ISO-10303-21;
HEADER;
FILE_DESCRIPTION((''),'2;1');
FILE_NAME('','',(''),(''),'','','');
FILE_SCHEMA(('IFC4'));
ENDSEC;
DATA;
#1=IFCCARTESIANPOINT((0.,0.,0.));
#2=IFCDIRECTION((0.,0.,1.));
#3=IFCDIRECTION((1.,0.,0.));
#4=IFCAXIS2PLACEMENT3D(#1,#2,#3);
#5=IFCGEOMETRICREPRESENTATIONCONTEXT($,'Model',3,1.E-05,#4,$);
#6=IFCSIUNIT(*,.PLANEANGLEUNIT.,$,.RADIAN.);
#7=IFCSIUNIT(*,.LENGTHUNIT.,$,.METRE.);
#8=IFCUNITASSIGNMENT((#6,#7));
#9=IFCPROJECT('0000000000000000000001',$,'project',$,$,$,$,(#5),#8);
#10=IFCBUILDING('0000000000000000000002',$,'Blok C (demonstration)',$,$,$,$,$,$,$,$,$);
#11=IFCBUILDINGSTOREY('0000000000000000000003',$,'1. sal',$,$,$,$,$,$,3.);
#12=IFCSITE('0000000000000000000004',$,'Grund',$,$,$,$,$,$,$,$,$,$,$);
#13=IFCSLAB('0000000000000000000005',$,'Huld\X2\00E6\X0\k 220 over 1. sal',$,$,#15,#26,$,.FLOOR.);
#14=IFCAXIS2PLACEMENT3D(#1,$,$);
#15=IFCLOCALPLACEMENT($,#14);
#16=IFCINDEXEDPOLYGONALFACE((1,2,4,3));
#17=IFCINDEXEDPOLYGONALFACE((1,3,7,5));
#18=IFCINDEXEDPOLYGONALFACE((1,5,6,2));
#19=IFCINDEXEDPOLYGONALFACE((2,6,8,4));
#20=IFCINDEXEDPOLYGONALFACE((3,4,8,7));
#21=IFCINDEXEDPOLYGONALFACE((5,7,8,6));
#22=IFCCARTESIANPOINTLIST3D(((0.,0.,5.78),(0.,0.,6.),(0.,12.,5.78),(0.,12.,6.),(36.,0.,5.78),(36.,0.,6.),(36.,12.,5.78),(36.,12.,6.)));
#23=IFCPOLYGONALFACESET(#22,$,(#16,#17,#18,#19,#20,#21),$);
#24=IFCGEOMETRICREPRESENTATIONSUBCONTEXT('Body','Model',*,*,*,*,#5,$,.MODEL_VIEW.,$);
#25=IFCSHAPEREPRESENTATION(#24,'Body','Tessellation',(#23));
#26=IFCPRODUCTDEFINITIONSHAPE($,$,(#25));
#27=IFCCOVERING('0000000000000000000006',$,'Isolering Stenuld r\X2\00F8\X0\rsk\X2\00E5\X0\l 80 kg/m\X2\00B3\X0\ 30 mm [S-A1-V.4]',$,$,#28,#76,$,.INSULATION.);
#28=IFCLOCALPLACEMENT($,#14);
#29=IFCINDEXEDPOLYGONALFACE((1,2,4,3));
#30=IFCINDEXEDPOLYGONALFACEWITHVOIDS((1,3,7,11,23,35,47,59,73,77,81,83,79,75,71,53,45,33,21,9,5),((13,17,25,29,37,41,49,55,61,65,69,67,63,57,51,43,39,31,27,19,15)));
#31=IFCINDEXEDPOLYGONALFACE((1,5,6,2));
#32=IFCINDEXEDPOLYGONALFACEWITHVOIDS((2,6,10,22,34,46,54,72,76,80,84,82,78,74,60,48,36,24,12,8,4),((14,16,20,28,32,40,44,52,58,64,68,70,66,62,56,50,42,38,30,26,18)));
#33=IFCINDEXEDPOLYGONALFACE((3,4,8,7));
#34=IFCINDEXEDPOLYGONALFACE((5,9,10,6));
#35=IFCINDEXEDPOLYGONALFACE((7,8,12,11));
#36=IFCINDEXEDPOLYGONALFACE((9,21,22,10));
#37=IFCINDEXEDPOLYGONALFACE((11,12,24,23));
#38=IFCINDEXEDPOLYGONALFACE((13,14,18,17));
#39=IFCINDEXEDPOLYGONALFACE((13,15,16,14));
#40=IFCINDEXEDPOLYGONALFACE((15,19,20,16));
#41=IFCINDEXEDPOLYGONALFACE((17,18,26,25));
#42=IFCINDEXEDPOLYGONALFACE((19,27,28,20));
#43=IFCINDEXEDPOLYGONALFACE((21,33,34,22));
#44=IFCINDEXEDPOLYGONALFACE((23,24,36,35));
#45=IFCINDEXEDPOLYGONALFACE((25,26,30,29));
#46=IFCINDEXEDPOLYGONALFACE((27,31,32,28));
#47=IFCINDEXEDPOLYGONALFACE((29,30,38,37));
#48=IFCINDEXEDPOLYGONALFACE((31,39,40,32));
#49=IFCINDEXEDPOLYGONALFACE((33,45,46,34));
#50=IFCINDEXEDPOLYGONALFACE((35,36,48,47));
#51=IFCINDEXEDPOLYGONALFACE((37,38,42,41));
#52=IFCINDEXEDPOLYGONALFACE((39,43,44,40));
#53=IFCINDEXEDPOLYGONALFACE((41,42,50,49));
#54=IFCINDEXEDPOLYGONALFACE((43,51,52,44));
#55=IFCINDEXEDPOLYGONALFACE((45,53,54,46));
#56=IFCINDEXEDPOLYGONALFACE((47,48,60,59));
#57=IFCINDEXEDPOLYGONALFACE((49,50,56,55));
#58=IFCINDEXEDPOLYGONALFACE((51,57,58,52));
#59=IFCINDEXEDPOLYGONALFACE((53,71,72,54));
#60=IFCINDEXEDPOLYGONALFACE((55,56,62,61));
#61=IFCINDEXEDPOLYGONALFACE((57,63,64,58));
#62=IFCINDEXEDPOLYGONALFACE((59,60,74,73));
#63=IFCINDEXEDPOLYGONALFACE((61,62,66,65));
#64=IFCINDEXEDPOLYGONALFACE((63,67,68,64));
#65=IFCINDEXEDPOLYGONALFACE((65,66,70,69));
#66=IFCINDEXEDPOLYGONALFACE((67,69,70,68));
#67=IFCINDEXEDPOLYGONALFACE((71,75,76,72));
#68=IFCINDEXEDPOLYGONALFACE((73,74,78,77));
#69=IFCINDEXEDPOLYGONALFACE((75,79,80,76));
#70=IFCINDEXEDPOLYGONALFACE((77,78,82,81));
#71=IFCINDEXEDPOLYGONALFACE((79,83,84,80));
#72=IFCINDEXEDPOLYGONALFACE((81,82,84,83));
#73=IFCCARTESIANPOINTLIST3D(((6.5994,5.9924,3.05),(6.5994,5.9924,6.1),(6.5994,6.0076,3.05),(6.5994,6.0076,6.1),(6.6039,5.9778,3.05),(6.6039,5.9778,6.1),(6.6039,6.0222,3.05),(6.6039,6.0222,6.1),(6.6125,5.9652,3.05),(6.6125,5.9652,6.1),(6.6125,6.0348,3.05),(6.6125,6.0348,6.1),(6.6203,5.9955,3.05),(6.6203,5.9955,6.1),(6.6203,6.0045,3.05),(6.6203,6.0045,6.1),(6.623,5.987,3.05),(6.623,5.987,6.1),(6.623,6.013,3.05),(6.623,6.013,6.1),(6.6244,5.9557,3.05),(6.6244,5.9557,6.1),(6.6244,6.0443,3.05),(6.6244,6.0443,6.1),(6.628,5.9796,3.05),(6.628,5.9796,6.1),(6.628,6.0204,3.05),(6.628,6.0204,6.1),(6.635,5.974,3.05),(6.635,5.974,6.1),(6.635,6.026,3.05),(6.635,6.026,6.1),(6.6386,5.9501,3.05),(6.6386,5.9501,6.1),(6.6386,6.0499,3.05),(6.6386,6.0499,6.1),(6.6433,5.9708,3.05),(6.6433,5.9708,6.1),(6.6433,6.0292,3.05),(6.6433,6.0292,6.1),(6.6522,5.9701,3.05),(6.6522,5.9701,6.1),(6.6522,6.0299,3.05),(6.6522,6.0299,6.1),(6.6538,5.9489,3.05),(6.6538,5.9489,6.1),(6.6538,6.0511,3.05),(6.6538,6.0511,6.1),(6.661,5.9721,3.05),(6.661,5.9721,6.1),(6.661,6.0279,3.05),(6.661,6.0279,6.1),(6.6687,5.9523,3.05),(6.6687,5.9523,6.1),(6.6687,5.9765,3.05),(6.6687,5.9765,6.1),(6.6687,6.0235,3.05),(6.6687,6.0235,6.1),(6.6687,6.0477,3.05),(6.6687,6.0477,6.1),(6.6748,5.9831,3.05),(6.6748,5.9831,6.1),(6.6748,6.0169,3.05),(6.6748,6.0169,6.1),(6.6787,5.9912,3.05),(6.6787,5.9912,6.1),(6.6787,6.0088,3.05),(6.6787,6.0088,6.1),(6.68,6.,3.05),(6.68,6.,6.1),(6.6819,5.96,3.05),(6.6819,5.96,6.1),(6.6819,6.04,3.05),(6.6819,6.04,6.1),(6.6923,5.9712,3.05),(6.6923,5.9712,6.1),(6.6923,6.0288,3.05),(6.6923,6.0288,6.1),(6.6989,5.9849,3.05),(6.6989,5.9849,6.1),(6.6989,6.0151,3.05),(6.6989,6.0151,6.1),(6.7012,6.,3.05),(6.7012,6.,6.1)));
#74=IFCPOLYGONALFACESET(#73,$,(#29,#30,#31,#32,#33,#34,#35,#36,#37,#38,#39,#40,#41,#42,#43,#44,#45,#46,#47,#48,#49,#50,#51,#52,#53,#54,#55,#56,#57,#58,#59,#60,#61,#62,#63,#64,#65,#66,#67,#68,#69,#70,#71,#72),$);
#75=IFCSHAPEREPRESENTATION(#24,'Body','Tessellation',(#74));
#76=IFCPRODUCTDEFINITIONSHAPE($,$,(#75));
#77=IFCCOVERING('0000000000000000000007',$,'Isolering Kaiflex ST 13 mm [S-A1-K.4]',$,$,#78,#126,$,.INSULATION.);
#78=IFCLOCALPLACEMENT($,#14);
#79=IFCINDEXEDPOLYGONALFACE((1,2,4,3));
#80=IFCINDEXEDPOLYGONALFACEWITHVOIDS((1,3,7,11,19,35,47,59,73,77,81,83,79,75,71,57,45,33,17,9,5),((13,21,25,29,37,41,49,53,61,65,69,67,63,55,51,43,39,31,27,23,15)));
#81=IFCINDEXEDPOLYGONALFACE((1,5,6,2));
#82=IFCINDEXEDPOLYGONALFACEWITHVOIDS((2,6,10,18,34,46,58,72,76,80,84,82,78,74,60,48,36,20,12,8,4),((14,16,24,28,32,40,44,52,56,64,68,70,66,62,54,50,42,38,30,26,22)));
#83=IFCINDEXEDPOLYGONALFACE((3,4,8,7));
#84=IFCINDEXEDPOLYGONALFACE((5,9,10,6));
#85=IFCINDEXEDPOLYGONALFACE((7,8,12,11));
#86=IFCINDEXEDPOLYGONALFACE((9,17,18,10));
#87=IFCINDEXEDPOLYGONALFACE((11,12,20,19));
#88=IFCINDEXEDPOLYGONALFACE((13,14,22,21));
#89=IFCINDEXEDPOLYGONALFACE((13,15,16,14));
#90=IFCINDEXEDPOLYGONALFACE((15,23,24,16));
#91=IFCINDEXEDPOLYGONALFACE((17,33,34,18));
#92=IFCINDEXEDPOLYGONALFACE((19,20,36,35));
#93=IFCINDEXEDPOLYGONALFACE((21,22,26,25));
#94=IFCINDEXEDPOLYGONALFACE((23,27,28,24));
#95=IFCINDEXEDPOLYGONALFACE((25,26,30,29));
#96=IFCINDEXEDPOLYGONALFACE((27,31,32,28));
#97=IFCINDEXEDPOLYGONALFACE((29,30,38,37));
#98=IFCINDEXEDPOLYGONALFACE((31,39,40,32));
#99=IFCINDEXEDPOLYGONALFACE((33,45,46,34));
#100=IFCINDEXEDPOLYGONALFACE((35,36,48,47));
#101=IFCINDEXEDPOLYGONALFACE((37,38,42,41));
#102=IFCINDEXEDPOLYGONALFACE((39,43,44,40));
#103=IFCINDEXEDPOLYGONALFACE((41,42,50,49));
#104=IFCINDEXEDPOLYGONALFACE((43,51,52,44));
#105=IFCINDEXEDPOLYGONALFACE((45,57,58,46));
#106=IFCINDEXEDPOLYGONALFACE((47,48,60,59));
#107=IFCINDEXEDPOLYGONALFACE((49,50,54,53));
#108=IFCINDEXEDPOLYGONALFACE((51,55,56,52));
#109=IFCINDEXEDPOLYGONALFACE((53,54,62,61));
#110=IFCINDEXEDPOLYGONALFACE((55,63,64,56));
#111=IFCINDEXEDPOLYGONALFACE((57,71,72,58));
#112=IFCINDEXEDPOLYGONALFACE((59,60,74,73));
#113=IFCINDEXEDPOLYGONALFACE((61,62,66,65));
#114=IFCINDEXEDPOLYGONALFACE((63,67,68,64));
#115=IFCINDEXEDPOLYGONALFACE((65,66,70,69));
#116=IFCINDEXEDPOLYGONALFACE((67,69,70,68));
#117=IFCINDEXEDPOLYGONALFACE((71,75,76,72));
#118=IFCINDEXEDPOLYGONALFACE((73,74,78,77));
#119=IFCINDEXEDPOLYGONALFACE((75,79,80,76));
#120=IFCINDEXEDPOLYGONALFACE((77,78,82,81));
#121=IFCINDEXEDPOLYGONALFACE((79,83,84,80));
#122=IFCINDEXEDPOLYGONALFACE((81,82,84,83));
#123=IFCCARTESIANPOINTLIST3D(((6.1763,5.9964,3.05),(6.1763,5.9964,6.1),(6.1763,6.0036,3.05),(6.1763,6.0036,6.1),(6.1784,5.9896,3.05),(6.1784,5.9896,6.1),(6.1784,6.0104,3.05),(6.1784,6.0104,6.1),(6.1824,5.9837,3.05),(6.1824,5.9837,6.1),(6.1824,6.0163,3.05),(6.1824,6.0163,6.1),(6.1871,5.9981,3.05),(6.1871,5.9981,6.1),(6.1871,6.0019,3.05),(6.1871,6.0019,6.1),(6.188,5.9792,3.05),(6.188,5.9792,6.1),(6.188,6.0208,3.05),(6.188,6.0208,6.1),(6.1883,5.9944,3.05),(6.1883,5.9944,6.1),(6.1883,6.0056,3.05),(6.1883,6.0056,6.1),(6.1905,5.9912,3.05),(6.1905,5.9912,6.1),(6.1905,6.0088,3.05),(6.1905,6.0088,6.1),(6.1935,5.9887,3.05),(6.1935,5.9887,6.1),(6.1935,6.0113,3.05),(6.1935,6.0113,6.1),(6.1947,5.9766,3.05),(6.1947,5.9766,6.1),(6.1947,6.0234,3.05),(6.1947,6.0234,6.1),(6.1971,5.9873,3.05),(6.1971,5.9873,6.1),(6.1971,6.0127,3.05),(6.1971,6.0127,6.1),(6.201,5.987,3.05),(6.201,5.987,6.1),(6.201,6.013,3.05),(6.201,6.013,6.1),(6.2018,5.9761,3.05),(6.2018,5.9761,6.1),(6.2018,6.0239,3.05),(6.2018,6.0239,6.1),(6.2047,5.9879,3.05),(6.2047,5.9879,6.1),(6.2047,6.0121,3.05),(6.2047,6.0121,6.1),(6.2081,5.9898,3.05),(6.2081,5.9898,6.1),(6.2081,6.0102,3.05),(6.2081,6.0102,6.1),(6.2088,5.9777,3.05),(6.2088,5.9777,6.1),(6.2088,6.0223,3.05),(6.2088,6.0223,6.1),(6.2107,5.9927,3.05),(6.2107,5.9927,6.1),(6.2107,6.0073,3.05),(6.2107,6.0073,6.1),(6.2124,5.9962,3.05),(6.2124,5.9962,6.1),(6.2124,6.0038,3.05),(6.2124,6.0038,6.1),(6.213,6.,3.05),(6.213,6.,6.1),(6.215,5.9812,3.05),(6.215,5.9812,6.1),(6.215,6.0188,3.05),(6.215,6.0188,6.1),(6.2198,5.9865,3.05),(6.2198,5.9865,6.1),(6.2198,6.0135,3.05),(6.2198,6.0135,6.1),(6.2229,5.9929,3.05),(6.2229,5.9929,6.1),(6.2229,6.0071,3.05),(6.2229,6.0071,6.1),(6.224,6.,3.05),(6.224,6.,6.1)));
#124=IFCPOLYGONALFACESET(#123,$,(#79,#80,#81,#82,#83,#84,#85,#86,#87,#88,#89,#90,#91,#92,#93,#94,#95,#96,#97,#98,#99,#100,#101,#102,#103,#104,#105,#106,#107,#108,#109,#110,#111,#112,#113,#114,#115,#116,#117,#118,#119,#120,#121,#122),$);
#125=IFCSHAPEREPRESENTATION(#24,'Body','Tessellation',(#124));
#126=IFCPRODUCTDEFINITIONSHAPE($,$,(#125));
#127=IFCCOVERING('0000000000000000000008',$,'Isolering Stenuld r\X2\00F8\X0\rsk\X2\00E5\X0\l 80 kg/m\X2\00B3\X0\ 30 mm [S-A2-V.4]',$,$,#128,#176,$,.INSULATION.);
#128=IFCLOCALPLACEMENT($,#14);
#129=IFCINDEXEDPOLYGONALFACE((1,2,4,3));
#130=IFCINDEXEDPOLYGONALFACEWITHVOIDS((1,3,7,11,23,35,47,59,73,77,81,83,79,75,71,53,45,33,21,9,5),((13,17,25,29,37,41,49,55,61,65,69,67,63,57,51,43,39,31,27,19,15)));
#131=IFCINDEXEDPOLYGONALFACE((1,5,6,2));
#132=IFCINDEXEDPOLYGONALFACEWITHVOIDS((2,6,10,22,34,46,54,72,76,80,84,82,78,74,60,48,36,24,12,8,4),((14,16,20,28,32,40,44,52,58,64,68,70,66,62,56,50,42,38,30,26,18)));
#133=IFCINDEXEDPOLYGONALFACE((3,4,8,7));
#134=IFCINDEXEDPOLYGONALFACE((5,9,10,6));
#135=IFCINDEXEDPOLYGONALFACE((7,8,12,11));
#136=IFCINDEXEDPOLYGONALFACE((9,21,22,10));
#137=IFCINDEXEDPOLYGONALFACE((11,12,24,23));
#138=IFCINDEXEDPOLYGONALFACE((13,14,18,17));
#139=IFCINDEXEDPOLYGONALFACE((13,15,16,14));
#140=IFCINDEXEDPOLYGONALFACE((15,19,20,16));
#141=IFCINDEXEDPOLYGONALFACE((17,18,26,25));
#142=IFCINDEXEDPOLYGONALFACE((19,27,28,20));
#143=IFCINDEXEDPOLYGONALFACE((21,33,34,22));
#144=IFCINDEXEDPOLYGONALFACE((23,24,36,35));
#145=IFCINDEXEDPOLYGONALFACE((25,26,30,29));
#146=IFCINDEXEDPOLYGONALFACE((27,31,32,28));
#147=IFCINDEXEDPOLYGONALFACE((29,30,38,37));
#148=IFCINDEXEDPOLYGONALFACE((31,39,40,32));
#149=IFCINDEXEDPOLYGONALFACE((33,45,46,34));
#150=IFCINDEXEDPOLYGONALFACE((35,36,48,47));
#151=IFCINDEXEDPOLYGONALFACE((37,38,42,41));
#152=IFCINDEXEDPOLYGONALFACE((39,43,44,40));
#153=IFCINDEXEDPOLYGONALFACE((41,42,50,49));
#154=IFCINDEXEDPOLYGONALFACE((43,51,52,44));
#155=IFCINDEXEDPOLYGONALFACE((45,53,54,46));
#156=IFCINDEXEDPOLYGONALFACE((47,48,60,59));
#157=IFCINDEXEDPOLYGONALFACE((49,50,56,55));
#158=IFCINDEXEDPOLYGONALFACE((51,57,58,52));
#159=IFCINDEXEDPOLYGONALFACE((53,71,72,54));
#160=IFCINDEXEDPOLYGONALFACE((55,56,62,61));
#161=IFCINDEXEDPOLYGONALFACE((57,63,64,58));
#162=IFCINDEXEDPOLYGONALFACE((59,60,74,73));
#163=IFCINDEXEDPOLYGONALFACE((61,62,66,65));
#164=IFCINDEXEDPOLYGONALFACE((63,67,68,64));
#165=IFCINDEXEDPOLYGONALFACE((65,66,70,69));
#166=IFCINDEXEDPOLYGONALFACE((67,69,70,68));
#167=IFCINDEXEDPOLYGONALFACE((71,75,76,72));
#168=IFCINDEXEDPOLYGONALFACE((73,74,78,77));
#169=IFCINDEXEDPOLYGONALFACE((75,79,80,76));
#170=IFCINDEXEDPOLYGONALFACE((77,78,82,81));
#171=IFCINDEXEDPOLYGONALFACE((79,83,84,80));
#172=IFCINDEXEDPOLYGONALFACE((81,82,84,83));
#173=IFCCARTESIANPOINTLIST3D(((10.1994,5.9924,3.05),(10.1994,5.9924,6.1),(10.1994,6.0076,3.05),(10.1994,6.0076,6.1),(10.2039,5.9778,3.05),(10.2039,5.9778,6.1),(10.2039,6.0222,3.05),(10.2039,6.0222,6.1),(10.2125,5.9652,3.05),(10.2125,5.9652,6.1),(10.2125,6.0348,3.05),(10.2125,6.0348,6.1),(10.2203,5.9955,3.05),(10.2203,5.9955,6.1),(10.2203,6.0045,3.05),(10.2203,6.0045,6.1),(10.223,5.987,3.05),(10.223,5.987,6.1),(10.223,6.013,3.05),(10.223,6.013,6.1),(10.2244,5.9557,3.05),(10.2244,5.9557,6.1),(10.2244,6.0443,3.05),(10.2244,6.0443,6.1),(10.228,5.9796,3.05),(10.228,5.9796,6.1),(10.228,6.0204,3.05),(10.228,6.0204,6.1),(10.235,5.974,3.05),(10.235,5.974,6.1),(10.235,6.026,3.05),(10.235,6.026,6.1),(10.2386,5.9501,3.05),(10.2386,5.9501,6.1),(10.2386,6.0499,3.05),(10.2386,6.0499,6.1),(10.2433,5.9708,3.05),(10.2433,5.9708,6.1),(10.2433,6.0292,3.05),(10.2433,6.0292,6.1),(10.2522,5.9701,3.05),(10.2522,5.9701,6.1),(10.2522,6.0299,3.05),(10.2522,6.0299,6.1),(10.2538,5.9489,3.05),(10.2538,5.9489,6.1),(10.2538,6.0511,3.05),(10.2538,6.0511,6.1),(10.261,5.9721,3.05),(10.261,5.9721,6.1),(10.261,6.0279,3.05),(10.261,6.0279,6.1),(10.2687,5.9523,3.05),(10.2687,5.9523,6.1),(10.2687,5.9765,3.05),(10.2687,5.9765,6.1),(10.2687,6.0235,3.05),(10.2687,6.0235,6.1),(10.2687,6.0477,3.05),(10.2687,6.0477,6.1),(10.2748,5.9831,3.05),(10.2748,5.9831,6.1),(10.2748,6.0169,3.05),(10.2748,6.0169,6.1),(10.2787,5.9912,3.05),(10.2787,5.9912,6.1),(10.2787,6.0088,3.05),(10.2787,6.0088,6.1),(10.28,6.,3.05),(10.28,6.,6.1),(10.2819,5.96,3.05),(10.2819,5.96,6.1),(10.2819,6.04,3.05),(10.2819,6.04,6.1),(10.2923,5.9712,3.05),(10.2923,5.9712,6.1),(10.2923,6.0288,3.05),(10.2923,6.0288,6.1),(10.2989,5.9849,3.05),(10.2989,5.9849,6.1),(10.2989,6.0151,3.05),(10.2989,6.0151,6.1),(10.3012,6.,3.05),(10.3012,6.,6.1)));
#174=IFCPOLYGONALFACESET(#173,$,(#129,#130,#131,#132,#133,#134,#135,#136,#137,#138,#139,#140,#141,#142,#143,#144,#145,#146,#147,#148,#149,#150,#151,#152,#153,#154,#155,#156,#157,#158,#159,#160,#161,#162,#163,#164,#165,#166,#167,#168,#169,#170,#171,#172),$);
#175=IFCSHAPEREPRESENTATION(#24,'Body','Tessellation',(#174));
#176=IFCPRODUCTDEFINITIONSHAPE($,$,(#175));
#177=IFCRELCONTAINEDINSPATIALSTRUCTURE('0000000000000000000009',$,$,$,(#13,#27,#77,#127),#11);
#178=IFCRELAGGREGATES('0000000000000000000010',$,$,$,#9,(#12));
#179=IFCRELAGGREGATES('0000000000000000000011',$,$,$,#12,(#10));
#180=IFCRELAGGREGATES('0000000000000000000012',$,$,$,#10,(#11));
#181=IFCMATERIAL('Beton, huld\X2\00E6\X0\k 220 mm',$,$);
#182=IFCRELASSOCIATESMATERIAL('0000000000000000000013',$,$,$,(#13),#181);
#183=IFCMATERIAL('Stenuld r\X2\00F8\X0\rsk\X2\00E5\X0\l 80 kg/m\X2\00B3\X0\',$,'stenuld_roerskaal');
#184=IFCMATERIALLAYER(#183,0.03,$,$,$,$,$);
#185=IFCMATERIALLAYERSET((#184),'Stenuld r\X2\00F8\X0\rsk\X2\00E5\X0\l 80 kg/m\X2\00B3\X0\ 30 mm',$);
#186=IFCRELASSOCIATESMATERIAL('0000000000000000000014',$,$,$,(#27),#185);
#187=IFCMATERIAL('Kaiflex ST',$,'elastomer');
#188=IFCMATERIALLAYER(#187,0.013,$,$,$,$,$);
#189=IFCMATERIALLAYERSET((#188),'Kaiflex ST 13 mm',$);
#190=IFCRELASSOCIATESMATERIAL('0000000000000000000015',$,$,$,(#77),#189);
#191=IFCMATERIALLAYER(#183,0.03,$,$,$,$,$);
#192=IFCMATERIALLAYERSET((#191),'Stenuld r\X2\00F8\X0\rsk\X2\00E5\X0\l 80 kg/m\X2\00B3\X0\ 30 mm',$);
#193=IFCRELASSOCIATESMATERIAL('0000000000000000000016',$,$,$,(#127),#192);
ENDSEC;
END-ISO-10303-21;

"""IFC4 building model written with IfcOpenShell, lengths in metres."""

from ifc_helpers import new_model, si_unit, frame, origin_with_axes, place, context, subcontext, project, spatial, polyline, hollow_circle, outline, extrude, material, layer, layer_set, element, save


model = new_model("IFC4")

# Units and contexts
model_context = context("Model", 3, precision=1e-05, world=origin_with_axes())
body_context = subcontext(model_context, "Body", "Model", "MODEL_VIEW")
ifc_project = project(units=[si_unit("PLANEANGLEUNIT", "RADIAN"), si_unit("LENGTHUNIT", "METRE")], contexts=[model_context])

# Site, building, storey
site = spatial("IfcSite", under=ifc_project, Name="Grund")
building = spatial("IfcBuilding", under=site, Name="Blok C (demonstration)")
storey = spatial("IfcBuildingStorey", under=building, Name="1. sal", Elevation=3.0)

# Slab
ifc_material_1 = material(Name="Beton, huldæk 220 mm")
slab_placement = place(None, origin_with_axes())
element("IfcSlab", 1, at=slab_placement, inside=storey, material=ifc_material_1, Name="Huldæk 220 over 1. sal", PredefinedType="FLOOR", context=body_context, shape_type="SweptSolid", body=[
    extrude(outline(polyline([(0.0, 0.0), (36.0, 0.0), (36.0, 12.0), (0.0, 12.0), (0.0, 0.0)])), frame((0.0, 0.0, 5.78)), (0.0, 0.0, 1.0), 0.22),
])

# Coverings
ifc_material_2 = material(Name="Stenuld rørskål 80 kg/m³", Category="stenuld_roerskaal")
ifc_layer_1 = layer(ifc_material_2, 0.03)
ifc_layer_set_1 = layer_set([ifc_layer_1], Name="Stenuld rørskål 80 kg/m³ 30 mm")
covering_1_placement = place(None, origin_with_axes())
element("IfcCovering", 2, at=covering_1_placement, inside=storey, material=ifc_layer_set_1, Name="Isolering Stenuld rørskål 80 kg/m³ 30 mm [S-A1-V.4]", PredefinedType="INSULATION", context=body_context, shape_type="SweptSolid", body=[
    extrude(hollow_circle(Radius=0.0512, WallThickness=0.0212), frame((6.65, 6.0, 3.05), z_axis=(0.0, 0.0, 1.0), x_axis=(1.0, 0.0, 0.0)), (0.0, 0.0, 1.0), 3.05),
])
ifc_material_3 = material(Name="Kaiflex ST", Category="elastomer")
ifc_layer_2 = layer(ifc_material_3, 0.013)
ifc_layer_set_2 = layer_set([ifc_layer_2], Name="Kaiflex ST 13 mm")
covering_2_placement = place(None, origin_with_axes())
element("IfcCovering", 3, at=covering_2_placement, inside=storey, material=ifc_layer_set_2, Name="Isolering Kaiflex ST 13 mm [S-A1-K.4]", PredefinedType="INSULATION", context=body_context, shape_type="SweptSolid", body=[
    extrude(hollow_circle(Radius=0.024, WallThickness=0.011), frame((6.2, 6.0, 3.05), z_axis=(0.0, 0.0, 1.0), x_axis=(1.0, 0.0, 0.0)), (0.0, 0.0, 1.0), 3.05),
])
ifc_layer_3 = layer(ifc_material_2, 0.03)
ifc_layer_set_3 = layer_set([ifc_layer_3], Name="Stenuld rørskål 80 kg/m³ 30 mm")
covering_3_placement = place(None, origin_with_axes())
element("IfcCovering", 4, at=covering_3_placement, inside=storey, material=ifc_layer_set_3, Name="Isolering Stenuld rørskål 80 kg/m³ 30 mm [S-A2-V.4]", PredefinedType="INSULATION", context=body_context, shape_type="SweptSolid", body=[
    extrude(hollow_circle(Radius=0.0512, WallThickness=0.0212), frame((10.25, 6.0, 3.05), z_axis=(0.0, 0.0, 1.0), x_axis=(1.0, 0.0, 0.0)), (0.0, 0.0, 1.0), 3.05),
])

save(model, "model.ifc")
